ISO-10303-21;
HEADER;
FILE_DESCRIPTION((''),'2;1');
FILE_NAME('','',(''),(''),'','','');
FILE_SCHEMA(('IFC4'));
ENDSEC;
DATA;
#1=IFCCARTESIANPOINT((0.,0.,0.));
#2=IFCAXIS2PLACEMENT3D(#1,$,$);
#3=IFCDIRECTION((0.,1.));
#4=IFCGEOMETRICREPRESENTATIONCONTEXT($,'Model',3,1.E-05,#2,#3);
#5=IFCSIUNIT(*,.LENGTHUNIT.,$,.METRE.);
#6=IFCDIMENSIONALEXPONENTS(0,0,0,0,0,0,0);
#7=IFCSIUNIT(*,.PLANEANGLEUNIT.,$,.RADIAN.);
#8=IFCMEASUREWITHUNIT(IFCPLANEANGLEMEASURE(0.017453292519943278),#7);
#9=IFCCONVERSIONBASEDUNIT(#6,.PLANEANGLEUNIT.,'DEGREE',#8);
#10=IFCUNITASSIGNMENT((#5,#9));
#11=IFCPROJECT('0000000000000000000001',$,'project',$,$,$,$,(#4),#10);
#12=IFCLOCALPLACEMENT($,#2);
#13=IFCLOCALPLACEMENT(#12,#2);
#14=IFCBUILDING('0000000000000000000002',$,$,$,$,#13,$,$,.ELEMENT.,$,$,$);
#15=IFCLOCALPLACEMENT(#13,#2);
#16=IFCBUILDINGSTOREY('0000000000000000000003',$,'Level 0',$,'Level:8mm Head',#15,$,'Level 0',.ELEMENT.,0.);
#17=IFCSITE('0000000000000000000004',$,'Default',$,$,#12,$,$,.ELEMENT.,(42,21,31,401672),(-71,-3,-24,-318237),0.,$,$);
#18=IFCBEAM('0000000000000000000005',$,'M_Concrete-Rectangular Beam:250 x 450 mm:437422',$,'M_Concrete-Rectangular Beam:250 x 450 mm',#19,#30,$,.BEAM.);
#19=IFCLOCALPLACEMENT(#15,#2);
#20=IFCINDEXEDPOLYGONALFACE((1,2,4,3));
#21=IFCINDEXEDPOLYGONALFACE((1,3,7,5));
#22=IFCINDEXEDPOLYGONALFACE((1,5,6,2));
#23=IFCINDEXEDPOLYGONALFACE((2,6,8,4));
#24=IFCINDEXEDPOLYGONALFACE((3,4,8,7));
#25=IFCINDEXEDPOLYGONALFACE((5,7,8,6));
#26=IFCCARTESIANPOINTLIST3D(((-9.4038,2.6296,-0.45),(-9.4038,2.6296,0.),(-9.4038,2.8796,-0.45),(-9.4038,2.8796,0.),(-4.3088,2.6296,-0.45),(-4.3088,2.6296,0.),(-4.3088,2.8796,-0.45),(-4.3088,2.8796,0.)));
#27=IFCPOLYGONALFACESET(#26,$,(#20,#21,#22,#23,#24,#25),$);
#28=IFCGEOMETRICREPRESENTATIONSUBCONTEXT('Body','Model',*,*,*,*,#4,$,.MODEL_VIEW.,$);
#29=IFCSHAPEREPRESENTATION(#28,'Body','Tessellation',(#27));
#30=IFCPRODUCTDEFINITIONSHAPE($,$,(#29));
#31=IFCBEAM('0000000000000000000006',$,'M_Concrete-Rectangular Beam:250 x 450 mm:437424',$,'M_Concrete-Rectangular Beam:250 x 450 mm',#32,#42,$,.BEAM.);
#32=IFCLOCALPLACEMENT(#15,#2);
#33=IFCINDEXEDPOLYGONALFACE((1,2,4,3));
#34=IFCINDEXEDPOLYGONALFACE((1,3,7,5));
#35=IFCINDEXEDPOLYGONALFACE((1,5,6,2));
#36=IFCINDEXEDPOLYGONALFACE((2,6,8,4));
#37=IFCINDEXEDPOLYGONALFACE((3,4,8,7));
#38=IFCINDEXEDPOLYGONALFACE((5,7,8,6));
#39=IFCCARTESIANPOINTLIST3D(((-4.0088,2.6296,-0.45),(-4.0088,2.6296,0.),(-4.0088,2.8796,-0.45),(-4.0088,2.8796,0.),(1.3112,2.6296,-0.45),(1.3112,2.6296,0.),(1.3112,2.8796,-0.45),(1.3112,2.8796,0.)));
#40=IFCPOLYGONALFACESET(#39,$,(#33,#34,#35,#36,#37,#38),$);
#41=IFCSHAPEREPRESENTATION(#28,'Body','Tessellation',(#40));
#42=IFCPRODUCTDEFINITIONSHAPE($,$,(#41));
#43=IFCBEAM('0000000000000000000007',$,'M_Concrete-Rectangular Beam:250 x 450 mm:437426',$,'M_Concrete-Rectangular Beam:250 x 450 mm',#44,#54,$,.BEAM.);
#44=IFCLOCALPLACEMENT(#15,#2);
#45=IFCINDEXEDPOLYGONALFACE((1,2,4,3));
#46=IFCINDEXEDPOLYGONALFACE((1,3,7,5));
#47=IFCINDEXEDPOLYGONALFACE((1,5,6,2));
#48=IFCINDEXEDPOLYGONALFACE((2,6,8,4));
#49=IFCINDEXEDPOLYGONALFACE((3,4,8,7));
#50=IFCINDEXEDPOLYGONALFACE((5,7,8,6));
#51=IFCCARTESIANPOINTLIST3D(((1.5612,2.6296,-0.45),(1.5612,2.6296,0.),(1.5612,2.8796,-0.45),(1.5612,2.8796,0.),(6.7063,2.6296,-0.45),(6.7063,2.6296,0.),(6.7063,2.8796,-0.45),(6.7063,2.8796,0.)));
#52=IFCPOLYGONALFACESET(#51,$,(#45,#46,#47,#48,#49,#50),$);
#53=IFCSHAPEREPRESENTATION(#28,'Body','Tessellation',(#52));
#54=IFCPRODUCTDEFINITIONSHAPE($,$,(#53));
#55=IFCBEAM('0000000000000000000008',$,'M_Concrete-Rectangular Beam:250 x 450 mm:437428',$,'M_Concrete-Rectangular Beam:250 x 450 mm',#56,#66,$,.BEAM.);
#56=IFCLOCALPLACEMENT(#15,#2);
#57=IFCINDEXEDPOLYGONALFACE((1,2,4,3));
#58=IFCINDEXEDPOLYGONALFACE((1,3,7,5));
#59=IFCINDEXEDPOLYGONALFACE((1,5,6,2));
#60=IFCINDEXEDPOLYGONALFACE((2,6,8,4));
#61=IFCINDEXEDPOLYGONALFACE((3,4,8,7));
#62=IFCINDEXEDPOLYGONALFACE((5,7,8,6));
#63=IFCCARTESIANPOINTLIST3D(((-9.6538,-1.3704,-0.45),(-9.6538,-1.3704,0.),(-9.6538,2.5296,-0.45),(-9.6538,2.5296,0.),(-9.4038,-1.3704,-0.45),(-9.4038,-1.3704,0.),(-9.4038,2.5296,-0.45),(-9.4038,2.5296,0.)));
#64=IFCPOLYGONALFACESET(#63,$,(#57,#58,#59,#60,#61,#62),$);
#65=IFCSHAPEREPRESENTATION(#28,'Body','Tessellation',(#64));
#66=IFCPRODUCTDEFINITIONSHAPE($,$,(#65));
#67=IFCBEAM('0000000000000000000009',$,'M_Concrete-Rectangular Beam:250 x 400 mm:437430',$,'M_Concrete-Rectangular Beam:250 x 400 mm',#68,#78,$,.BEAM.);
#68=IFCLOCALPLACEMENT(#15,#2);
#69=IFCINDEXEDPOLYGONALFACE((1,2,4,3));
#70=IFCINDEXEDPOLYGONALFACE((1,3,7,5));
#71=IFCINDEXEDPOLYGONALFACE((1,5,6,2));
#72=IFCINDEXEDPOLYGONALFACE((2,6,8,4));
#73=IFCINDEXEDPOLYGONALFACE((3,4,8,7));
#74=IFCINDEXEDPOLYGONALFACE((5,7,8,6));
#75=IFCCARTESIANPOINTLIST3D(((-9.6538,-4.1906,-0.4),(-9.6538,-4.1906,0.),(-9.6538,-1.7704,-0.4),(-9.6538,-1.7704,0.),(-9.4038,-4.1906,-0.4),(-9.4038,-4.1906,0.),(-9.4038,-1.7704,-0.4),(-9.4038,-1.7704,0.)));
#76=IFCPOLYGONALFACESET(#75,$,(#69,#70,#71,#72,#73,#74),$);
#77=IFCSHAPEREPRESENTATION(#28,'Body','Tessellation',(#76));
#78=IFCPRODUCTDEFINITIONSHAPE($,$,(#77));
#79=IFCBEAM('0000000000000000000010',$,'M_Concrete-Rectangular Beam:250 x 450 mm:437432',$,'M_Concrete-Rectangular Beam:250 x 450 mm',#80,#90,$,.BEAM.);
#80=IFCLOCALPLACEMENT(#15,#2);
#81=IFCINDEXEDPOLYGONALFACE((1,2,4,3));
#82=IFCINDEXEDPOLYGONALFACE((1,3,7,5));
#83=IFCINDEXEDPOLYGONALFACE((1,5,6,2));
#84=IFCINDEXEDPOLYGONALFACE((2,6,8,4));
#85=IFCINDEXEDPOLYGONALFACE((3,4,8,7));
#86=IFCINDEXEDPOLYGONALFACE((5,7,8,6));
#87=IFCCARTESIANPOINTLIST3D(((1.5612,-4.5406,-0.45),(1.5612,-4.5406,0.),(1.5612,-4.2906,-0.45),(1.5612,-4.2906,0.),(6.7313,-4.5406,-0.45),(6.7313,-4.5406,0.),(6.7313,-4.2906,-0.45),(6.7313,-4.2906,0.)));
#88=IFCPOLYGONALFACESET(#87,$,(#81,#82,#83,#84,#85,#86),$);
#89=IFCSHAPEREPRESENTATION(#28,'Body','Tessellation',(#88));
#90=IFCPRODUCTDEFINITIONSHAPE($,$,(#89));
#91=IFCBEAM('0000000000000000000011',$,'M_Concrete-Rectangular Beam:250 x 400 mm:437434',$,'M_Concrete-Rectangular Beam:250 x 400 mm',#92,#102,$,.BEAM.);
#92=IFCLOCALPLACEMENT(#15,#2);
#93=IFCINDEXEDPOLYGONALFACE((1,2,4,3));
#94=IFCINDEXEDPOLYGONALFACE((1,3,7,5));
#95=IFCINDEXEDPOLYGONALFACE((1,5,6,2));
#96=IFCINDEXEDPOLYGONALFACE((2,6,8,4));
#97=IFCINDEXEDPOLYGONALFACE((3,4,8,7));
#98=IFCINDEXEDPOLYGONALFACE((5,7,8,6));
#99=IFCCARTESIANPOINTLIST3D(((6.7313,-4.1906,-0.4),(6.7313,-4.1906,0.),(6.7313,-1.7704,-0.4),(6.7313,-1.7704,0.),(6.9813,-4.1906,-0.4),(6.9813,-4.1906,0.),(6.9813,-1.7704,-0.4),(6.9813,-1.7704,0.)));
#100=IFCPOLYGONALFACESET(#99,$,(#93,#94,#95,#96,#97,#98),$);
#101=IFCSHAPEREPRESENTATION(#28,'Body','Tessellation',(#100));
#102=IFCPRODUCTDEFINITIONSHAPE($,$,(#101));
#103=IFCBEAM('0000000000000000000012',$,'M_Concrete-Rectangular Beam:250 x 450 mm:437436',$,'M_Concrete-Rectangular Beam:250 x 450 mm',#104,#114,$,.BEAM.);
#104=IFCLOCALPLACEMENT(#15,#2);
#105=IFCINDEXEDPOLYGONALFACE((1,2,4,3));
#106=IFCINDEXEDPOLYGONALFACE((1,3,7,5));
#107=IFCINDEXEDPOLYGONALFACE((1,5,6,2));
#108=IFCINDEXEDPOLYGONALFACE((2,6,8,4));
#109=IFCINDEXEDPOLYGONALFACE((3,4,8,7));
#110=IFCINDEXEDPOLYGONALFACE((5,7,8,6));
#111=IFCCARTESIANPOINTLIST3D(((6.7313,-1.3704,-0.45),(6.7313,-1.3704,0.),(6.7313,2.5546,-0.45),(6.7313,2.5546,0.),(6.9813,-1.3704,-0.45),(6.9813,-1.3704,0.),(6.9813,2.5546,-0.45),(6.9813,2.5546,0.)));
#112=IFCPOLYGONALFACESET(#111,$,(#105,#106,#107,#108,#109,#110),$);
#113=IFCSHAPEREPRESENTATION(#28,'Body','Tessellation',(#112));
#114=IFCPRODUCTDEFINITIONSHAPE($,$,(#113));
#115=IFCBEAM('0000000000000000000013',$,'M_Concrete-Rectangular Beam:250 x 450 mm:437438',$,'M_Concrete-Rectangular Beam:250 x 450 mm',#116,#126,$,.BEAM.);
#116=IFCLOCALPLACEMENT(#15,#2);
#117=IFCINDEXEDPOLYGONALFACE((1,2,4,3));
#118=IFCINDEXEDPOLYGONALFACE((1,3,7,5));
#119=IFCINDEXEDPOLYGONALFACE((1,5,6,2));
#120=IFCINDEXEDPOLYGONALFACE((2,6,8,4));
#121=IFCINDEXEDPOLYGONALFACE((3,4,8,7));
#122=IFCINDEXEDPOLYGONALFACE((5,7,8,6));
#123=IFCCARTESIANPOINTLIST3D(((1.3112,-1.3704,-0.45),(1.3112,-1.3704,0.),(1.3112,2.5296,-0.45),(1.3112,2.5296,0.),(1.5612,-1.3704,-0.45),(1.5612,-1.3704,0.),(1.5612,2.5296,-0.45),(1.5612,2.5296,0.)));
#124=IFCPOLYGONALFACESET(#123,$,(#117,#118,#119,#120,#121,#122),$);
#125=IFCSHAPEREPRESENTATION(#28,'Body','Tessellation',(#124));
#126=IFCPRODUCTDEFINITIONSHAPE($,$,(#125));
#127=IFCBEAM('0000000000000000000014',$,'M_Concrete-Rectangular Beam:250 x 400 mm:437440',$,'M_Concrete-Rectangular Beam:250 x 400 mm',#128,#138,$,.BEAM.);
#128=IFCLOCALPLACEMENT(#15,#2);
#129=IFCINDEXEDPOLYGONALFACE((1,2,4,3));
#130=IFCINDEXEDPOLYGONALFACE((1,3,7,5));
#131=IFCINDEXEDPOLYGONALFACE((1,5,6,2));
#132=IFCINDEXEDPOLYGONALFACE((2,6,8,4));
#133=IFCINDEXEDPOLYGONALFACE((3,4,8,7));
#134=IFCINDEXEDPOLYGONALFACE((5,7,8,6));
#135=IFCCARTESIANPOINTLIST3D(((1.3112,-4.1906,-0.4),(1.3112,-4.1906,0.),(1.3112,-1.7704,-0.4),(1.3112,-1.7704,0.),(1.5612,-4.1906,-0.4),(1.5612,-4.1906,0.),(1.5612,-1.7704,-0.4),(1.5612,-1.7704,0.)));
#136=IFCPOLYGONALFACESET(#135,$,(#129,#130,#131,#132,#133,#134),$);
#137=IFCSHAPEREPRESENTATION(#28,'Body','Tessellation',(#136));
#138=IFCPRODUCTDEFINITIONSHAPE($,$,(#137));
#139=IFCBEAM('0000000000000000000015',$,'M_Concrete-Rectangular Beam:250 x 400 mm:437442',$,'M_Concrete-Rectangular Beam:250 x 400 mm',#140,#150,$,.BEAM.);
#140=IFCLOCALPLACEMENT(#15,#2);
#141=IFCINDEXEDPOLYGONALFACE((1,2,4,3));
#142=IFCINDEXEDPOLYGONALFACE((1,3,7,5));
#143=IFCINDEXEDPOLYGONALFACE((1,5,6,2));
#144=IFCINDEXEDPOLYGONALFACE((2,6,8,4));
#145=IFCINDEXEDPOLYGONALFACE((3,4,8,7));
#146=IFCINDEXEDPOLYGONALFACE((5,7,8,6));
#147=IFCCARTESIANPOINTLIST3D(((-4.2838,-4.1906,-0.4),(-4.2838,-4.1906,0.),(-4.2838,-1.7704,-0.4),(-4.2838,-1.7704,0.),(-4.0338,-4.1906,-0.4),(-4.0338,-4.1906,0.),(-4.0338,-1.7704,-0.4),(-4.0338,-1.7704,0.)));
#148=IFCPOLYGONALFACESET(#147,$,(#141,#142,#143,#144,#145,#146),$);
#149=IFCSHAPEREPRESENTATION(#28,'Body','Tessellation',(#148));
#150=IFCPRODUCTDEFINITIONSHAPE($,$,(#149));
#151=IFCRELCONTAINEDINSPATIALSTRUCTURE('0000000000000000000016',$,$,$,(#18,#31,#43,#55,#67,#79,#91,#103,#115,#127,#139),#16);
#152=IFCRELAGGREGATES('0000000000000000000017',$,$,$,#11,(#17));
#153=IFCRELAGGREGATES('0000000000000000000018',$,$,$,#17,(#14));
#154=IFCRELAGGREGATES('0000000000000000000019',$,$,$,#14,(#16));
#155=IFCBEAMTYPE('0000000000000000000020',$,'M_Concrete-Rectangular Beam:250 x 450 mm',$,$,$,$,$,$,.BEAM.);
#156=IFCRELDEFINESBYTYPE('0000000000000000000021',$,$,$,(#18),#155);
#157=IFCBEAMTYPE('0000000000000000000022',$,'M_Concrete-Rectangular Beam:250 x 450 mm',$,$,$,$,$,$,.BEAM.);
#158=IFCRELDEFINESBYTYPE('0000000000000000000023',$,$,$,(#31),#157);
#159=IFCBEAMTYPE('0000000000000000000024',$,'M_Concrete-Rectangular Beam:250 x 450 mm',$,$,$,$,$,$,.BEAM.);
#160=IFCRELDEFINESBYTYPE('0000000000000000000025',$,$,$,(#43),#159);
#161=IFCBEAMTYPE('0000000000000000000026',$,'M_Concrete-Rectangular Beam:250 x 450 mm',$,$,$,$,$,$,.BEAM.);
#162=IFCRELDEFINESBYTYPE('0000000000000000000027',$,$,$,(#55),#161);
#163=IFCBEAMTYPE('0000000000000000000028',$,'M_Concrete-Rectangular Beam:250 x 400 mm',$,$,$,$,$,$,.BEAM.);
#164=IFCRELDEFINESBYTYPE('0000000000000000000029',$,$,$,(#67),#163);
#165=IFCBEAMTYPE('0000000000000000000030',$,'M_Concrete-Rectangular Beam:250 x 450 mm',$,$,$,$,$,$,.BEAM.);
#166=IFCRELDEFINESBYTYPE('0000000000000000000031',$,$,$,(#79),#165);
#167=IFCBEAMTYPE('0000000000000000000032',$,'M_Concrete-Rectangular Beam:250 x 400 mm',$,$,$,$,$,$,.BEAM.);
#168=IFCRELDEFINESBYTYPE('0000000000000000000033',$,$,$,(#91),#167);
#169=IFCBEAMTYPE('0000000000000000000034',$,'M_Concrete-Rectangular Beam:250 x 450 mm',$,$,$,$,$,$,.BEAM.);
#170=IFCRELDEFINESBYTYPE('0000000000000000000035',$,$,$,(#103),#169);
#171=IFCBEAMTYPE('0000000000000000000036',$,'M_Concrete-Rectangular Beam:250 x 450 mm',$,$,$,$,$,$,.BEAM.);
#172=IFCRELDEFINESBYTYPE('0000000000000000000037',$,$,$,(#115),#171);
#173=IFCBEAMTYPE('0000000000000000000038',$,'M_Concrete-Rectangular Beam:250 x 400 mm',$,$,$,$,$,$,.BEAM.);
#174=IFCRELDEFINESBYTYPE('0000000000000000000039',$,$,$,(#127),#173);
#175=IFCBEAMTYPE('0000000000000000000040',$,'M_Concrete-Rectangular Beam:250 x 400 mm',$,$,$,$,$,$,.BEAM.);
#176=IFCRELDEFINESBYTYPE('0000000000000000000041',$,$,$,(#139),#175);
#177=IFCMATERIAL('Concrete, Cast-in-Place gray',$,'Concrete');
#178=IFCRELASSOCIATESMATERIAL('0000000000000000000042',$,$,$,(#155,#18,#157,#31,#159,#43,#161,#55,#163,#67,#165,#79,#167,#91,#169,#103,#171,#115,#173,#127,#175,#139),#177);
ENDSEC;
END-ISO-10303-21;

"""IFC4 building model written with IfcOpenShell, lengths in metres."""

from ifc_helpers import new_model, entity, si_unit, converted_unit, direction, frame, origin, place, context, subcontext, project, spatial, indexed_curve, outline, extrude, source, transform, mapped, material, type_object, type_shapes, element, save


model = new_model("IFC4")

# Units and contexts
model_context = context("Model", 3, precision=1e-05, world=origin(), true_north=direction((0.0, 1.0)))
body_context = subcontext(model_context, "Body", "Model", "MODEL_VIEW")
ifc_project = project(units=[si_unit("LENGTHUNIT", "METRE"), converted_unit("PLANEANGLEUNIT", "DEGREE", entity("IfcPlaneAngleMeasure", 0.017453292519943278), si_unit("PLANEANGLEUNIT", "RADIAN"), dimensions=[0, 0, 0, 0, 0, 0, 0])], contexts=[model_context])

# Site, building, storey
site_placement = place(None, origin())
site = spatial("IfcSite", under=ifc_project, at=site_placement, Name="Default", CompositionType="ELEMENT", RefLatitude=(42, 21, 31, 401672), RefLongitude=(-71, -3, -24, -318237), RefElevation=0.0)
building_placement = place(site_placement, origin())
building = spatial("IfcBuilding", under=site, at=building_placement, CompositionType="ELEMENT")
storey_placement = place(building_placement, origin())
storey = spatial("IfcBuildingStorey", under=building, at=storey_placement, Name="Level 0", ObjectType="Level:8mm Head", LongName="Level 0", CompositionType="ELEMENT", Elevation=0.0)

# Beams
ifc_material = material(Name="Concrete, Cast-in-Place gray", Category="Concrete")
beam_type_1 = type_object("IfcBeamType", Name="M_Concrete-Rectangular Beam:250 x 450 mm", PredefinedType="BEAM", material=ifc_material)
shared_shape_1 = source(origin(), body_context, "Body", "SweptSolid", [
    extrude(outline(indexed_curve([(-0.225, -0.125), (0.225, -0.125), (0.225, 0.125), (-0.225, 0.125), (-0.225, -0.125)], self_intersect=False)), frame((-9.4038, 2.7546, -0.225), z_axis=(1.0, 0.0, 0.0), x_axis=(0.0, 0.0, -1.0)), (0.0, 0.0, 1.0), 5.095),
])
type_shapes(beam_type_1, [shared_shape_1])
beam_1_placement = place(storey_placement, origin())
element("IfcBeam", 1, at=beam_1_placement, inside=storey, type_object=beam_type_1, material=ifc_material, Name="M_Concrete-Rectangular Beam:250 x 450 mm:437422", ObjectType="M_Concrete-Rectangular Beam:250 x 450 mm", PredefinedType="BEAM", context=body_context, shape_type="MappedRepresentation", body=[
    mapped(shared_shape_1, transform((0.0, 0.0, 0.0), scale=1.0)),
])
beam_type_2 = type_object("IfcBeamType", Name="M_Concrete-Rectangular Beam:250 x 450 mm", PredefinedType="BEAM", material=ifc_material)
shared_shape_2 = source(origin(), body_context, "Body", "SweptSolid", [
    extrude(outline(indexed_curve([(-0.225, -0.125), (0.225, -0.125), (0.225, 0.125), (-0.225, 0.125), (-0.225, -0.125)], self_intersect=False)), frame((-4.0088, 2.7546, -0.225), z_axis=(1.0, 0.0, 0.0), x_axis=(0.0, 0.0, -1.0)), (0.0, 0.0, 1.0), 5.32),
])
type_shapes(beam_type_2, [shared_shape_2])
beam_2_placement = place(storey_placement, origin())
element("IfcBeam", 2, at=beam_2_placement, inside=storey, type_object=beam_type_2, material=ifc_material, Name="M_Concrete-Rectangular Beam:250 x 450 mm:437424", ObjectType="M_Concrete-Rectangular Beam:250 x 450 mm", PredefinedType="BEAM", context=body_context, shape_type="MappedRepresentation", body=[
    mapped(shared_shape_2, transform((0.0, 0.0, 0.0), scale=1.0)),
])
beam_type_3 = type_object("IfcBeamType", Name="M_Concrete-Rectangular Beam:250 x 450 mm", PredefinedType="BEAM", material=ifc_material)
shared_shape_3 = source(origin(), body_context, "Body", "SweptSolid", [
    extrude(outline(indexed_curve([(-0.225, -0.125), (0.225, -0.125), (0.225, 0.125), (-0.225, 0.125), (-0.225, -0.125)], self_intersect=False)), frame((1.5612, 2.7546, -0.225), z_axis=(1.0, 0.0, 0.0), x_axis=(0.0, 0.0, -1.0)), (0.0, 0.0, 1.0), 5.1451),
])
type_shapes(beam_type_3, [shared_shape_3])
beam_3_placement = place(storey_placement, origin())
element("IfcBeam", 3, at=beam_3_placement, inside=storey, type_object=beam_type_3, material=ifc_material, Name="M_Concrete-Rectangular Beam:250 x 450 mm:437426", ObjectType="M_Concrete-Rectangular Beam:250 x 450 mm", PredefinedType="BEAM", context=body_context, shape_type="MappedRepresentation", body=[
    mapped(shared_shape_3, transform((0.0, 0.0, 0.0), scale=1.0)),
])
beam_type_4 = type_object("IfcBeamType", Name="M_Concrete-Rectangular Beam:250 x 450 mm", PredefinedType="BEAM", material=ifc_material)
shared_shape_4 = source(origin(), body_context, "Body", "SweptSolid", [
    extrude(outline(indexed_curve([(-0.125, -0.225), (0.125, -0.225), (0.125, 0.225), (-0.125, 0.225), (-0.125, -0.225)], self_intersect=False)), frame((-9.5288, 2.5296, -0.225), z_axis=(0.0, -1.0, 0.0), x_axis=(-1.0, 0.0, 0.0)), (0.0, 0.0, 1.0), 3.9),
])
type_shapes(beam_type_4, [shared_shape_4])
beam_4_placement = place(storey_placement, origin())
element("IfcBeam", 4, at=beam_4_placement, inside=storey, type_object=beam_type_4, material=ifc_material, Name="M_Concrete-Rectangular Beam:250 x 450 mm:437428", ObjectType="M_Concrete-Rectangular Beam:250 x 450 mm", PredefinedType="BEAM", context=body_context, shape_type="MappedRepresentation", body=[
    mapped(shared_shape_4, transform((0.0, 0.0, 0.0), scale=1.0)),
])
beam_type_5 = type_object("IfcBeamType", Name="M_Concrete-Rectangular Beam:250 x 400 mm", PredefinedType="BEAM", material=ifc_material)
shared_shape_5 = source(origin(), body_context, "Body", "SweptSolid", [
    extrude(outline(indexed_curve([(-0.125, -0.2), (0.125, -0.2), (0.125, 0.2), (-0.125, 0.2), (-0.125, -0.2)], self_intersect=False)), frame((-9.5288, -1.7704, -0.2), z_axis=(0.0, -1.0, 0.0), x_axis=(-1.0, 0.0, 0.0)), (0.0, 0.0, 1.0), 2.4202),
])
type_shapes(beam_type_5, [shared_shape_5])
beam_5_placement = place(storey_placement, origin())
element("IfcBeam", 5, at=beam_5_placement, inside=storey, type_object=beam_type_5, material=ifc_material, Name="M_Concrete-Rectangular Beam:250 x 400 mm:437430", ObjectType="M_Concrete-Rectangular Beam:250 x 400 mm", PredefinedType="BEAM", context=body_context, shape_type="MappedRepresentation", body=[
    mapped(shared_shape_5, transform((0.0, 0.0, 0.0), scale=1.0)),
])
beam_type_6 = type_object("IfcBeamType", Name="M_Concrete-Rectangular Beam:250 x 450 mm", PredefinedType="BEAM", material=ifc_material)
shared_shape_6 = source(origin(), body_context, "Body", "SweptSolid", [
    extrude(outline(indexed_curve([(-0.225, -0.125), (0.225, -0.125), (0.225, 0.125), (-0.225, 0.125), (-0.225, -0.125)], self_intersect=False)), frame((1.5612, -4.4156, -0.225), z_axis=(1.0, 0.0, 0.0), x_axis=(0.0, 0.0, -1.0)), (0.0, 0.0, 1.0), 5.1701),
])
type_shapes(beam_type_6, [shared_shape_6])
beam_6_placement = place(storey_placement, origin())
element("IfcBeam", 6, at=beam_6_placement, inside=storey, type_object=beam_type_6, material=ifc_material, Name="M_Concrete-Rectangular Beam:250 x 450 mm:437432", ObjectType="M_Concrete-Rectangular Beam:250 x 450 mm", PredefinedType="BEAM", context=body_context, shape_type="MappedRepresentation", body=[
    mapped(shared_shape_6, transform((0.0, 0.0, 0.0), scale=1.0)),
])
beam_type_7 = type_object("IfcBeamType", Name="M_Concrete-Rectangular Beam:250 x 400 mm", PredefinedType="BEAM", material=ifc_material)
shared_shape_7 = source(origin(), body_context, "Body", "SweptSolid", [
    extrude(outline(indexed_curve([(-0.125, -0.2), (0.125, -0.2), (0.125, 0.2), (-0.125, 0.2), (-0.125, -0.2)], self_intersect=False)), frame((6.8563, -4.1906, -0.2), z_axis=(0.0, 1.0, 0.0), x_axis=(-1.0, 0.0, 0.0)), (0.0, 0.0, 1.0), 2.4202),
])
type_shapes(beam_type_7, [shared_shape_7])
beam_7_placement = place(storey_placement, origin())
element("IfcBeam", 7, at=beam_7_placement, inside=storey, type_object=beam_type_7, material=ifc_material, Name="M_Concrete-Rectangular Beam:250 x 400 mm:437434", ObjectType="M_Concrete-Rectangular Beam:250 x 400 mm", PredefinedType="BEAM", context=body_context, shape_type="MappedRepresentation", body=[
    mapped(shared_shape_7, transform((0.0, 0.0, 0.0), scale=1.0)),
])
beam_type_8 = type_object("IfcBeamType", Name="M_Concrete-Rectangular Beam:250 x 450 mm", PredefinedType="BEAM", material=ifc_material)
shared_shape_8 = source(origin(), body_context, "Body", "SweptSolid", [
    extrude(outline(indexed_curve([(-0.125, -0.225), (0.125, -0.225), (0.125, 0.225), (-0.125, 0.225), (-0.125, -0.225)], self_intersect=False)), frame((6.8563, -1.3704, -0.225), z_axis=(0.0, 1.0, 0.0), x_axis=(-1.0, 0.0, 0.0)), (0.0, 0.0, 1.0), 3.925),
])
type_shapes(beam_type_8, [shared_shape_8])
beam_8_placement = place(storey_placement, origin())
element("IfcBeam", 8, at=beam_8_placement, inside=storey, type_object=beam_type_8, material=ifc_material, Name="M_Concrete-Rectangular Beam:250 x 450 mm:437436", ObjectType="M_Concrete-Rectangular Beam:250 x 450 mm", PredefinedType="BEAM", context=body_context, shape_type="MappedRepresentation", body=[
    mapped(shared_shape_8, transform((0.0, 0.0, 0.0), scale=1.0)),
])
beam_type_9 = type_object("IfcBeamType", Name="M_Concrete-Rectangular Beam:250 x 450 mm", PredefinedType="BEAM", material=ifc_material)
shared_shape_9 = source(origin(), body_context, "Body", "SweptSolid", [
    extrude(outline(indexed_curve([(-0.125, -0.225), (0.125, -0.225), (0.125, 0.225), (-0.125, 0.225), (-0.125, -0.225)], self_intersect=False)), frame((1.4362, -1.3704, -0.225), z_axis=(0.0, 1.0, 0.0), x_axis=(-1.0, 0.0, 0.0)), (0.0, 0.0, 1.0), 3.9),
])
type_shapes(beam_type_9, [shared_shape_9])
beam_9_placement = place(storey_placement, origin())
element("IfcBeam", 9, at=beam_9_placement, inside=storey, type_object=beam_type_9, material=ifc_material, Name="M_Concrete-Rectangular Beam:250 x 450 mm:437438", ObjectType="M_Concrete-Rectangular Beam:250 x 450 mm", PredefinedType="BEAM", context=body_context, shape_type="MappedRepresentation", body=[
    mapped(shared_shape_9, transform((0.0, 0.0, 0.0), scale=1.0)),
])
beam_type_10 = type_object("IfcBeamType", Name="M_Concrete-Rectangular Beam:250 x 400 mm", PredefinedType="BEAM", material=ifc_material)
shared_shape_10 = source(origin(), body_context, "Body", "SweptSolid", [
    extrude(outline(indexed_curve([(-0.125, -0.2), (0.125, -0.2), (0.125, 0.2), (-0.125, 0.2), (-0.125, -0.2)], self_intersect=False)), frame((1.4362, -1.7704, -0.2), z_axis=(0.0, -1.0, 0.0), x_axis=(-1.0, 0.0, 0.0)), (0.0, 0.0, 1.0), 2.4202),
])
type_shapes(beam_type_10, [shared_shape_10])
beam_10_placement = place(storey_placement, origin())
element("IfcBeam", 10, at=beam_10_placement, inside=storey, type_object=beam_type_10, material=ifc_material, Name="M_Concrete-Rectangular Beam:250 x 400 mm:437440", ObjectType="M_Concrete-Rectangular Beam:250 x 400 mm", PredefinedType="BEAM", context=body_context, shape_type="MappedRepresentation", body=[
    mapped(shared_shape_10, transform((0.0, 0.0, 0.0), scale=1.0)),
])
beam_type_11 = type_object("IfcBeamType", Name="M_Concrete-Rectangular Beam:250 x 400 mm", PredefinedType="BEAM", material=ifc_material)
shared_shape_11 = source(origin(), body_context, "Body", "SweptSolid", [
    extrude(outline(indexed_curve([(-0.125, -0.2), (0.125, -0.2), (0.125, 0.2), (-0.125, 0.2), (-0.125, -0.2)], self_intersect=False)), frame((-4.1588, -1.7704, -0.2), z_axis=(0.0, -1.0, 0.0), x_axis=(-1.0, 0.0, 0.0)), (0.0, 0.0, 1.0), 2.4202),
])
type_shapes(beam_type_11, [shared_shape_11])
beam_11_placement = place(storey_placement, origin())
element("IfcBeam", 11, at=beam_11_placement, inside=storey, type_object=beam_type_11, material=ifc_material, Name="M_Concrete-Rectangular Beam:250 x 400 mm:437442", ObjectType="M_Concrete-Rectangular Beam:250 x 400 mm", PredefinedType="BEAM", context=body_context, shape_type="MappedRepresentation", body=[
    mapped(shared_shape_11, transform((0.0, 0.0, 0.0), scale=1.0)),
])

save(model, "model.ifc")
